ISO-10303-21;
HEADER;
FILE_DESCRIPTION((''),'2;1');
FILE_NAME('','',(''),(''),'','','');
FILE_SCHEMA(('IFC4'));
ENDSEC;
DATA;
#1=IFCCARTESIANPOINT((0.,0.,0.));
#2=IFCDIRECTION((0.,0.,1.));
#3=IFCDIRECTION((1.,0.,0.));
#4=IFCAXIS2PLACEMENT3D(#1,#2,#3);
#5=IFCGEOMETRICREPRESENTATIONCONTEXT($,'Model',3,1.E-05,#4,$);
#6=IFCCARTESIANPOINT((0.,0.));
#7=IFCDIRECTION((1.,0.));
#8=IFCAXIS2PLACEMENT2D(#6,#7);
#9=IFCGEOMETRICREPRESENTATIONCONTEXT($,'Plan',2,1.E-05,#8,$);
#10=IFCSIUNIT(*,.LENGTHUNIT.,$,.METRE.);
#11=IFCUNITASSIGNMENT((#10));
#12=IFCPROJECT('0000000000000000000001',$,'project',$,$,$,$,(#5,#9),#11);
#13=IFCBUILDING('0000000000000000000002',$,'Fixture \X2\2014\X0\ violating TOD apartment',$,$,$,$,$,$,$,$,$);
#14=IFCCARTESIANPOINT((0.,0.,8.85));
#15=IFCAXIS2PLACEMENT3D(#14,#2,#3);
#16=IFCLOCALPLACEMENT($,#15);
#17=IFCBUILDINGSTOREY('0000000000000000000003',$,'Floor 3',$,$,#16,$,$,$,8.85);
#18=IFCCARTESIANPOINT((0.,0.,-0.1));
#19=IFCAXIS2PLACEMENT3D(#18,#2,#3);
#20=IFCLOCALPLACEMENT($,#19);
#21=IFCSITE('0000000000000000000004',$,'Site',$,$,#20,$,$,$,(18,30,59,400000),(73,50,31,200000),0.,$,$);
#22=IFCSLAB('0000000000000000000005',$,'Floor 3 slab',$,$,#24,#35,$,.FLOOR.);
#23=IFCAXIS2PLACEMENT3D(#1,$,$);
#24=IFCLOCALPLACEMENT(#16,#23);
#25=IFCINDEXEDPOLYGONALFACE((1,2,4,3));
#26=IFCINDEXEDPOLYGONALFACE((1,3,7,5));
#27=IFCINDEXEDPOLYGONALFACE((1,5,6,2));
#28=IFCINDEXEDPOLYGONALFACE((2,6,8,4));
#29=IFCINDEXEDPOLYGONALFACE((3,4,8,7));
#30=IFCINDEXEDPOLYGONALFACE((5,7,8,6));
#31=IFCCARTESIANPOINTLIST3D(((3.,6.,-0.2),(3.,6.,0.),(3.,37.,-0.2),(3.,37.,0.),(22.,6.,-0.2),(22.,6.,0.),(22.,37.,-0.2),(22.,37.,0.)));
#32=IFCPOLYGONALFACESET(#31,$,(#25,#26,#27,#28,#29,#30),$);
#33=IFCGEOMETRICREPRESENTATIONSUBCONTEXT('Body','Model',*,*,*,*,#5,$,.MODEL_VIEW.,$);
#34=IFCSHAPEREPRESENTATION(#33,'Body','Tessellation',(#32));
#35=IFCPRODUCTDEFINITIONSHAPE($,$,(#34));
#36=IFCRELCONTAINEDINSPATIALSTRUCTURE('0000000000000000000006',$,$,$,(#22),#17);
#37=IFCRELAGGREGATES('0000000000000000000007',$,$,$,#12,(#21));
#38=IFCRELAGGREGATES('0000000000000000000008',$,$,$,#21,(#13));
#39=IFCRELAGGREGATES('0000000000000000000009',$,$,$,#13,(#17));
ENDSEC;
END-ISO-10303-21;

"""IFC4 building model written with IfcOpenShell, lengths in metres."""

from ifc_helpers import new_model, si_unit, frame, origin_with_axes, origin_2d_with_axis, place, context, subcontext, project, spatial, line, indexed_curve, outline, extrude, element, save


model = new_model("IFC4")

# Units and contexts
model_context = context("Model", 3, precision=1e-05, world=origin_with_axes())
plan_context = context("Plan", 2, precision=1e-05, world=origin_2d_with_axis())
body_context = subcontext(model_context, "Body", "Model", "MODEL_VIEW")
ifc_project = project(units=[si_unit("LENGTHUNIT", "METRE")], contexts=[model_context, plan_context])

# Site, building, storey
site_placement = place(None, frame((0.0, 0.0, -0.1), z_axis=(0.0, 0.0, 1.0), x_axis=(1.0, 0.0, 0.0)))
site = spatial("IfcSite", under=ifc_project, at=site_placement, Name="Site", RefLatitude=(18, 30, 59, 400000), RefLongitude=(73, 50, 31, 200000), RefElevation=0.0)
building = spatial("IfcBuilding", under=site, Name="Fixture — violating TOD apartment")
storey_placement = place(None, frame((0.0, 0.0, 8.85), z_axis=(0.0, 0.0, 1.0), x_axis=(1.0, 0.0, 0.0)))
storey = spatial("IfcBuildingStorey", under=building, at=storey_placement, Name="Floor 3", Elevation=8.85)

# Slab
slab_placement = place(storey_placement, frame((0.0, 0.0, -0.2), z_axis=(0.0, 0.0, 1.0), x_axis=(1.0, 0.0, 0.0)))
element("IfcSlab", 1, at=slab_placement, inside=storey, Name="Floor 3 slab", PredefinedType="FLOOR", context=body_context, shape_type="SweptSolid", body=[
    extrude(outline(indexed_curve([(3.0, 6.0), (22.0, 6.0), (22.0, 37.0), (3.0, 37.0)], segments=[line(1, 2, 3, 4, 1)])), origin_with_axes(), (0.0, 0.0, 1.0), 0.2),
])

save(model, "model.ifc")
